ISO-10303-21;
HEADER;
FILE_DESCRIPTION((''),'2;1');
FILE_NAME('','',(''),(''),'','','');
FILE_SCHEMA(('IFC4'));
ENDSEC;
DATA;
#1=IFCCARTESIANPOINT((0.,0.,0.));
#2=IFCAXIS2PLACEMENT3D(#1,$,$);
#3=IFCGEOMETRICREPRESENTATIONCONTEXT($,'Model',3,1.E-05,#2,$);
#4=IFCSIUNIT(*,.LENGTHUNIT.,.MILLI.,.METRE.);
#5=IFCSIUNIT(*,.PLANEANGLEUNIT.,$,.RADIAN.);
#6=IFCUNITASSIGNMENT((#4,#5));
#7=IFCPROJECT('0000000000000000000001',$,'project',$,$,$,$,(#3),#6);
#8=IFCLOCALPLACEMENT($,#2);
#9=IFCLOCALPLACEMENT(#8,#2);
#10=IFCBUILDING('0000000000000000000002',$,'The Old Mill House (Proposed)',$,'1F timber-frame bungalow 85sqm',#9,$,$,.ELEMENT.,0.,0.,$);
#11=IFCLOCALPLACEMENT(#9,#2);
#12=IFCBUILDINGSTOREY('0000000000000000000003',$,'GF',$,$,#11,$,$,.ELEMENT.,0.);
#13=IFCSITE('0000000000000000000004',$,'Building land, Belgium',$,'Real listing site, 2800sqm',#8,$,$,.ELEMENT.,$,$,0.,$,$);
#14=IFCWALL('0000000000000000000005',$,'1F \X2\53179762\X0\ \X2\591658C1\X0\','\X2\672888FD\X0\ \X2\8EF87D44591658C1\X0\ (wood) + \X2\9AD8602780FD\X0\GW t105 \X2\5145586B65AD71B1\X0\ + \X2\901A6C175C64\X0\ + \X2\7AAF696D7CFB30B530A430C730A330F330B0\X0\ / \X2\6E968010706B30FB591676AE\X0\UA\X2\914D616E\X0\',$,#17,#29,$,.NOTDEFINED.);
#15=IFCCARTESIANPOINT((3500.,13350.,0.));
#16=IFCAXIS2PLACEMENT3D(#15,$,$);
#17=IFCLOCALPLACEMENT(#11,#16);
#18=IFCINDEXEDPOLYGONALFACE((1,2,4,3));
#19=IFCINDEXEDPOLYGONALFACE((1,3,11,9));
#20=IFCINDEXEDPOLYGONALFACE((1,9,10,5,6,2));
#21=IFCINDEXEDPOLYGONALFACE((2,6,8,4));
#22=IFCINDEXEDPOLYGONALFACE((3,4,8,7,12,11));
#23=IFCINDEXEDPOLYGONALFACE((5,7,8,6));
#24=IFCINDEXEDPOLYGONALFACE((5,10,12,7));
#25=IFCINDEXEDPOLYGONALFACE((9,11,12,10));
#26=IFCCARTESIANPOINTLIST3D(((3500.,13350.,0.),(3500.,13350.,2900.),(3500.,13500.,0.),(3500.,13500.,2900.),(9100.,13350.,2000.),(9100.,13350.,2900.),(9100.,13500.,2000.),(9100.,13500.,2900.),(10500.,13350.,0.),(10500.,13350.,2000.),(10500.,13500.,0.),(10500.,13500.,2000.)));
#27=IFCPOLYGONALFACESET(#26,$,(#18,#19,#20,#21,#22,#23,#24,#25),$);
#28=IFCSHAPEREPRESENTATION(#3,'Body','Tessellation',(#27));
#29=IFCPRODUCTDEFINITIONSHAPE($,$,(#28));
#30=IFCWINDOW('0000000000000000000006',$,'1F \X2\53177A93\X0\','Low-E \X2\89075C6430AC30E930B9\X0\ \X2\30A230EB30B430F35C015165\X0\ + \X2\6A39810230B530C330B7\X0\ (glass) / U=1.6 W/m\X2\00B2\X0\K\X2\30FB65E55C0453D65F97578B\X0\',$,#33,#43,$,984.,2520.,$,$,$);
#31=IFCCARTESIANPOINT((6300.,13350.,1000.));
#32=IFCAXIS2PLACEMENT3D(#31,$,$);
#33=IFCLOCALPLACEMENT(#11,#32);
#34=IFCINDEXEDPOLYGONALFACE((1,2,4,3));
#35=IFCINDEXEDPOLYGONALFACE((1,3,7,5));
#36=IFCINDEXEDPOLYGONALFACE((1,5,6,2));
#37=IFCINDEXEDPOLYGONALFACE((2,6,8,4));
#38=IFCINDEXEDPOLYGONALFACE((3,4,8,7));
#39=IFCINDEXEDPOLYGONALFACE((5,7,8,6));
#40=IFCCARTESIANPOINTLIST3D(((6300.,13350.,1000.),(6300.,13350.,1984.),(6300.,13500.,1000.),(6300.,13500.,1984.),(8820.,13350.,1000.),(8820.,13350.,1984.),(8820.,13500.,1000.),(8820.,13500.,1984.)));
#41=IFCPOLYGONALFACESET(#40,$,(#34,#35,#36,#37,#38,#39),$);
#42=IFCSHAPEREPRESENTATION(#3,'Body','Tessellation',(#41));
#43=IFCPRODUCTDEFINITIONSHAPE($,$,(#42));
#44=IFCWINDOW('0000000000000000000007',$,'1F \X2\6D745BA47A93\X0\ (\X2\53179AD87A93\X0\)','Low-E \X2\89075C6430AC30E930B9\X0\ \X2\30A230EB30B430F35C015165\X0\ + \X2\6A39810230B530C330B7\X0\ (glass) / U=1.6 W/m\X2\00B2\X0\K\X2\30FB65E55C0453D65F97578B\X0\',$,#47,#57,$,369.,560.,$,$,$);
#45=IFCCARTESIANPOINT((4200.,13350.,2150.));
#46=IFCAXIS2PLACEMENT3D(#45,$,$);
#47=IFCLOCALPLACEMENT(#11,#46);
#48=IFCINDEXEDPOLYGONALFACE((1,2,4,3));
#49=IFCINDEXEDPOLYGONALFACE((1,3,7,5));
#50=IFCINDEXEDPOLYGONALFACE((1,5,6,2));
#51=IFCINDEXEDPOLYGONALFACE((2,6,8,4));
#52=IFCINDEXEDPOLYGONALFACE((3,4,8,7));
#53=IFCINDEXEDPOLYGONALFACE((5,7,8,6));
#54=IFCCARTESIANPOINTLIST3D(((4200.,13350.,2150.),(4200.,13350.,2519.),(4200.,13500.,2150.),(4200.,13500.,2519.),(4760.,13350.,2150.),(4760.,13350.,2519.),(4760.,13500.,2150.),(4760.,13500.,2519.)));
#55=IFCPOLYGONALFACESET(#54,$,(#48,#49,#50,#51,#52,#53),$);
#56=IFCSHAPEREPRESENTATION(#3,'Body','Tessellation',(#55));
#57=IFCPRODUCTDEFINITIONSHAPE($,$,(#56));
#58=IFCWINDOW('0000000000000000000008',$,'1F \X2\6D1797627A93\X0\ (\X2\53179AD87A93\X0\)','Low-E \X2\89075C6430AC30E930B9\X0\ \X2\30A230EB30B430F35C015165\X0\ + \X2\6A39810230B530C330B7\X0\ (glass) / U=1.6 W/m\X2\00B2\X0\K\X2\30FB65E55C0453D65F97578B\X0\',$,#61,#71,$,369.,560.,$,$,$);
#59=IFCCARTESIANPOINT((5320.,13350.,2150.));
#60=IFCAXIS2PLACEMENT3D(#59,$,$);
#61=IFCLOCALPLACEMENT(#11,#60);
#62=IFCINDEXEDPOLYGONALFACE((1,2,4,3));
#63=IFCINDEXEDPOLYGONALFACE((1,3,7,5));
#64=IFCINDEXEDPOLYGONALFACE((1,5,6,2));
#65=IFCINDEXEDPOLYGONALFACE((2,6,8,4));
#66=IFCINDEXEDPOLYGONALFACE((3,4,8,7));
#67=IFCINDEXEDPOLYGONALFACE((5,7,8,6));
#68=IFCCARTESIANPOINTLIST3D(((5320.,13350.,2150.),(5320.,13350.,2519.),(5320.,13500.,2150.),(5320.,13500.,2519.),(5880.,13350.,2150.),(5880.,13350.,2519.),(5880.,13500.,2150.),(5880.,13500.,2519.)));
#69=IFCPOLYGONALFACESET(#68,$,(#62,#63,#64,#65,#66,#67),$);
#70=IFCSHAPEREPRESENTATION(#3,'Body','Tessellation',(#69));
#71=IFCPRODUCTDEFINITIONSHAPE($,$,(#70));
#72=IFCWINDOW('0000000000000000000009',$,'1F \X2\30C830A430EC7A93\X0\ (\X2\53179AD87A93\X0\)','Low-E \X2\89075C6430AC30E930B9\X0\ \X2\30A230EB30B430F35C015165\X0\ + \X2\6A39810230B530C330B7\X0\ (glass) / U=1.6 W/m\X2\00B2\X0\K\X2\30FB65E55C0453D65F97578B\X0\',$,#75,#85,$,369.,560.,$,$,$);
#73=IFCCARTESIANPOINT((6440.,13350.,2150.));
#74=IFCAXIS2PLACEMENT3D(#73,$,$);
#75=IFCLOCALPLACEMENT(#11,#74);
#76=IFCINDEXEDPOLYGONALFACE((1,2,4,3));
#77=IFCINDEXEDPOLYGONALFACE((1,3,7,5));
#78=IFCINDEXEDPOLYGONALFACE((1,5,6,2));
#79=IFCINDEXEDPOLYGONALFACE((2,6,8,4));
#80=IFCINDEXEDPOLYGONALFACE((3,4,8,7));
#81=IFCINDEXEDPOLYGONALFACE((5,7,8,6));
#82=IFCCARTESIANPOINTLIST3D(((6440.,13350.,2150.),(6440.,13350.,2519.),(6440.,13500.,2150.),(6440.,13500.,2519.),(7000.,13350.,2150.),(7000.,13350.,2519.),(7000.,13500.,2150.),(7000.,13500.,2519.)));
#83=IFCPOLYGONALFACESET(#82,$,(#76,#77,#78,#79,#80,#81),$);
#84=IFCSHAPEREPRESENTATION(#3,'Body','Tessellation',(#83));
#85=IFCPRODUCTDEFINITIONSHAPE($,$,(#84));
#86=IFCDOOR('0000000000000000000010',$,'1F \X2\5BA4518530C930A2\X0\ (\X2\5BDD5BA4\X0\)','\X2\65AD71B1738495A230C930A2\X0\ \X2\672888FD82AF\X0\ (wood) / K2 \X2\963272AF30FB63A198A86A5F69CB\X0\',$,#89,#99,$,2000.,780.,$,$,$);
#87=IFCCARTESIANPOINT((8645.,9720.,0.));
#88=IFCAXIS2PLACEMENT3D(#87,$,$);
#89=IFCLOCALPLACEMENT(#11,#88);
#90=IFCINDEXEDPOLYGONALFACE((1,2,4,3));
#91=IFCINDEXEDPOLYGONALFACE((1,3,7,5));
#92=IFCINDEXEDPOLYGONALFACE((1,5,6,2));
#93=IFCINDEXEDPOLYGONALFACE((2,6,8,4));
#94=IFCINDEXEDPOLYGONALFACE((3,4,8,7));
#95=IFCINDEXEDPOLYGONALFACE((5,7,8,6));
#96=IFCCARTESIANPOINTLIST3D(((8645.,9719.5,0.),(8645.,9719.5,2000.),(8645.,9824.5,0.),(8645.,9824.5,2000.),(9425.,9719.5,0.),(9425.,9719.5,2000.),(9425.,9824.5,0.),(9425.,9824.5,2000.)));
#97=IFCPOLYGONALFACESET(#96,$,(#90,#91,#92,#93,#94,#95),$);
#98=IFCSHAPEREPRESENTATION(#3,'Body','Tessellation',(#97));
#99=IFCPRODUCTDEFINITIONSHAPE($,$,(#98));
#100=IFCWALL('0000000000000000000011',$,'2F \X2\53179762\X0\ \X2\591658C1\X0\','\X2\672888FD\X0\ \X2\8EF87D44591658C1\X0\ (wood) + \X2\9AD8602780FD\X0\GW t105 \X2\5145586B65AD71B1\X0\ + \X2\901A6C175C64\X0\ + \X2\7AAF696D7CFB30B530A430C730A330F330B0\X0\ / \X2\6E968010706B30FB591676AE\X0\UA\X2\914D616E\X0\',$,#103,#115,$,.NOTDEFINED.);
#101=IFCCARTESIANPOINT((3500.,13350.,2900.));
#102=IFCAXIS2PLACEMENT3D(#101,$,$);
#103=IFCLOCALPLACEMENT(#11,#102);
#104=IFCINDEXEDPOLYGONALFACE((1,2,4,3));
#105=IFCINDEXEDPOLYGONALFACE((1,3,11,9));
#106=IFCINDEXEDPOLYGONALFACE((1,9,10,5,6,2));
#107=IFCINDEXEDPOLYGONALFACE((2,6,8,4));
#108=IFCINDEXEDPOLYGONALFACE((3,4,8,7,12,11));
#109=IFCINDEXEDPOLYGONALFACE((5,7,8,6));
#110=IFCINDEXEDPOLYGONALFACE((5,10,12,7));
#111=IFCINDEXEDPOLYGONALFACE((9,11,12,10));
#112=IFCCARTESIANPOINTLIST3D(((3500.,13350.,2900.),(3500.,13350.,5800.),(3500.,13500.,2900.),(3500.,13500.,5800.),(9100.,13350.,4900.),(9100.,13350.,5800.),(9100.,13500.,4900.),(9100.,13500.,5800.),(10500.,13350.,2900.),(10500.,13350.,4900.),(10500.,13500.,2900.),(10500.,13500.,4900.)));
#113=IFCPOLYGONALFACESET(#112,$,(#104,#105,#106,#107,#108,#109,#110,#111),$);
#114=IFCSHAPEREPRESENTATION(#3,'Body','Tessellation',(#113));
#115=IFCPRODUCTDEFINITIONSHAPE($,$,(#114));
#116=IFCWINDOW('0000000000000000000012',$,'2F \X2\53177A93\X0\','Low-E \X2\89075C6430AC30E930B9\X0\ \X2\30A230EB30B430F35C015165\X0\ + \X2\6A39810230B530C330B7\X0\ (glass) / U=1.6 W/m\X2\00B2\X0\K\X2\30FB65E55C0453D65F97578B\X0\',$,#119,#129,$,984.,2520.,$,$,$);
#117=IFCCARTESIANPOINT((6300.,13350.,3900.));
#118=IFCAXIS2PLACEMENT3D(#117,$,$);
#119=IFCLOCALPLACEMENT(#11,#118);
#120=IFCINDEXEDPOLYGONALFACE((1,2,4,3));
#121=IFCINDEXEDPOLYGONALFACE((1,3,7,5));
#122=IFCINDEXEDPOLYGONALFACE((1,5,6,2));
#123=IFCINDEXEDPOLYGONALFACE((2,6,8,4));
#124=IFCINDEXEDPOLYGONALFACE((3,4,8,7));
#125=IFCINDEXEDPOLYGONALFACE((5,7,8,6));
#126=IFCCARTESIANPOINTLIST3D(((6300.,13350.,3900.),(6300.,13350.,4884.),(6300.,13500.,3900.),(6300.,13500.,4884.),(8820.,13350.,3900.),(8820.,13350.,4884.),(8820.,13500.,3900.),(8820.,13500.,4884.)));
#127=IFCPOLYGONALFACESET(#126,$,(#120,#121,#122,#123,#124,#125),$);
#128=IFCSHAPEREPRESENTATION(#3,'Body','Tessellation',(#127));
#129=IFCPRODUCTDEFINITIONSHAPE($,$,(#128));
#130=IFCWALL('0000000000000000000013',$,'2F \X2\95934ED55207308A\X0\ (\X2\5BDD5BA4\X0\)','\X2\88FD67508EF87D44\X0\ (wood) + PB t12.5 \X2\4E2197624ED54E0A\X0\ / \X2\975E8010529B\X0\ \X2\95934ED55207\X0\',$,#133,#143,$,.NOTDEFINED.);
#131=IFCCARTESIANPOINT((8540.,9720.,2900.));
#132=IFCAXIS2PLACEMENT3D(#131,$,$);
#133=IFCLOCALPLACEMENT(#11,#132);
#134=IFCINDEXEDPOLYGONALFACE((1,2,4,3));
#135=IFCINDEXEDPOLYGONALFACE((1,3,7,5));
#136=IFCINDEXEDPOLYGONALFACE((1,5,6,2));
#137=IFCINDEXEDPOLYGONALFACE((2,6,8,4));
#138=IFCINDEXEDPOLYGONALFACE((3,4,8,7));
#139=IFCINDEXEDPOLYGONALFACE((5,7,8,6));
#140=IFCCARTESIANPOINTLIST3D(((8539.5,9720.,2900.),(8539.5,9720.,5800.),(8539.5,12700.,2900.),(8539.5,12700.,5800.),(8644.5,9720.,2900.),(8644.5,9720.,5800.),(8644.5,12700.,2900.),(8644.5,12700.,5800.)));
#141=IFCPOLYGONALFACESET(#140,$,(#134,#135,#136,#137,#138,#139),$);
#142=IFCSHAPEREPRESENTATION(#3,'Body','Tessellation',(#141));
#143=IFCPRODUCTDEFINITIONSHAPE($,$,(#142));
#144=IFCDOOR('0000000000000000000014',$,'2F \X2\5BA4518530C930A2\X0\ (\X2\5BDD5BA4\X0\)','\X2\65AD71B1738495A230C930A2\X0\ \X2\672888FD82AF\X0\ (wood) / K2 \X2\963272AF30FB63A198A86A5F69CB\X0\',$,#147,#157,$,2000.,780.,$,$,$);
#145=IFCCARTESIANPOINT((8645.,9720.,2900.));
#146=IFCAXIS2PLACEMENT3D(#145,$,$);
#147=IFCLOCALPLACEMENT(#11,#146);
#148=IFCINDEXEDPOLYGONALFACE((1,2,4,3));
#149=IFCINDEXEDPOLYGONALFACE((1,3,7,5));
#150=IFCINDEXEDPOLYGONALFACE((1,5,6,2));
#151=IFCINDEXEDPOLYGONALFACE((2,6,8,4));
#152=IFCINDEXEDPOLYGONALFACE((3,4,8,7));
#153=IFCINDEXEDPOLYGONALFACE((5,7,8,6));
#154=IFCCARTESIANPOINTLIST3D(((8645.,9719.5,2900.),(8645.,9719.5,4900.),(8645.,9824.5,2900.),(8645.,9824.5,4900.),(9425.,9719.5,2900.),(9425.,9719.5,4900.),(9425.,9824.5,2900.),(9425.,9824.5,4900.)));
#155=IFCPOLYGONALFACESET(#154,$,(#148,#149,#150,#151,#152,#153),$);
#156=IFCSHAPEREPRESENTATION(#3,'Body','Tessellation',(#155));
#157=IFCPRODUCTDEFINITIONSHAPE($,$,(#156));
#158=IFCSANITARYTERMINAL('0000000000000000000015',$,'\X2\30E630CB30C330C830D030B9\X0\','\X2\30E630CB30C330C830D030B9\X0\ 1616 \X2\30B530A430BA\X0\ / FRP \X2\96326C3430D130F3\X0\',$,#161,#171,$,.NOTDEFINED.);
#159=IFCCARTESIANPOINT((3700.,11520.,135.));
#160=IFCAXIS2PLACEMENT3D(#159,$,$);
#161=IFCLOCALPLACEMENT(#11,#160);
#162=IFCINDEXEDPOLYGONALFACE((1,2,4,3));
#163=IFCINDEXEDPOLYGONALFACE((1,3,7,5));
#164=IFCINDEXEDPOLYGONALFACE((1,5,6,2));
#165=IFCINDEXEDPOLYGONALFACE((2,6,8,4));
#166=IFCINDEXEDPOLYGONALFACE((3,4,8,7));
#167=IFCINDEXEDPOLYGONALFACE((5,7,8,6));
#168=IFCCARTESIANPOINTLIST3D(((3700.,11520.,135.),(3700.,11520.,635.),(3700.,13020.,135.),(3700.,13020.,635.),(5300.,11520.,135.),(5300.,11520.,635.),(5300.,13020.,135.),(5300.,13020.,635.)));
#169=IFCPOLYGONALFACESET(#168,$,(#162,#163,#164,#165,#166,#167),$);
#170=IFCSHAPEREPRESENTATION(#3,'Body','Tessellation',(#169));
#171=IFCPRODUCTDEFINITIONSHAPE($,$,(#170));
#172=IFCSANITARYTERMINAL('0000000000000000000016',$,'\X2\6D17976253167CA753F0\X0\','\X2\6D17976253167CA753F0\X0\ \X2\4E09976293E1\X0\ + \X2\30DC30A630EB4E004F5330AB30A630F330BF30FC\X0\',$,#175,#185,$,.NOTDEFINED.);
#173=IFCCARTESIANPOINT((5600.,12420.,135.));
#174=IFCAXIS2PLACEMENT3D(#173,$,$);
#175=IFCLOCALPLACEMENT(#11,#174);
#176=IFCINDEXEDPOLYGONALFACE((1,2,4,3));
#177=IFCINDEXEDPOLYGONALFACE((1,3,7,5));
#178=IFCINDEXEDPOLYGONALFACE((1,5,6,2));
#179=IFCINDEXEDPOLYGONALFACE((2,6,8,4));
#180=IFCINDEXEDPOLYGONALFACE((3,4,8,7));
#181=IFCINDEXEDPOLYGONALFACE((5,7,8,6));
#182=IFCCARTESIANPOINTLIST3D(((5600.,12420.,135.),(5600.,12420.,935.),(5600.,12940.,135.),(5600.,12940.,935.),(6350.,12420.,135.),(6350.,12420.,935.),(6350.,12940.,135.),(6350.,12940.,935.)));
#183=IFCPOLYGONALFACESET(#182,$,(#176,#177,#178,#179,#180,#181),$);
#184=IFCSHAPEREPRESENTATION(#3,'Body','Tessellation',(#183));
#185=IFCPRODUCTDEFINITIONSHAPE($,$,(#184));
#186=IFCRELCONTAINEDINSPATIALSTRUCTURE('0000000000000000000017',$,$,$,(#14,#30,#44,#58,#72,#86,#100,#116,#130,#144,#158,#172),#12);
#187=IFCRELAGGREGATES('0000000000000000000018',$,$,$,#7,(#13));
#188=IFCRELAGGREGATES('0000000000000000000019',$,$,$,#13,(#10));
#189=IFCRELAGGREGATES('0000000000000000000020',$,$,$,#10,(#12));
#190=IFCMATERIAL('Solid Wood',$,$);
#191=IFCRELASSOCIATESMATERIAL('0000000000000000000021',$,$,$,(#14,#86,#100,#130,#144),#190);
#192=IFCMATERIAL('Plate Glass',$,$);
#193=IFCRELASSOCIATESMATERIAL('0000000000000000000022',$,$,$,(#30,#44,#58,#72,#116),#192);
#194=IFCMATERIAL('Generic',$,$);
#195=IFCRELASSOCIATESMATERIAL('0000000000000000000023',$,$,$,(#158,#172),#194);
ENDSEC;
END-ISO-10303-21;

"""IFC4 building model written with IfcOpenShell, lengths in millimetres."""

from ifc_helpers import new_model, si_unit, frame, frame_2d, origin, place, context, project, spatial, rectangle, extrude, material, element, fill, save


model = new_model("IFC4")

# Units and contexts
model_context = context("Model", 3, precision=1e-05, world=origin())
ifc_project = project(units=[si_unit("LENGTHUNIT", "METRE", prefix="MILLI"), si_unit("PLANEANGLEUNIT", "RADIAN")], contexts=[model_context])

# Site, building, storey
site_placement = place(None, origin())
site = spatial("IfcSite", under=ifc_project, at=site_placement, Name="Building land, Belgium", ObjectType="Real listing site, 2800sqm", CompositionType="ELEMENT", RefElevation=0.0)
building_placement = place(site_placement, origin())
building = spatial("IfcBuilding", under=site, at=building_placement, Name="The Old Mill House (Proposed)", ObjectType="1F timber-frame bungalow 85sqm", CompositionType="ELEMENT", ElevationOfRefHeight=0.0, ElevationOfTerrain=0.0)
storey_placement = place(building_placement, origin())
storey = spatial("IfcBuildingStorey", under=building, at=storey_placement, Name="GF", CompositionType="ELEMENT", Elevation=0.0)

# Wall, openings, windows
ifc_material_1 = material(Name="Solid Wood")
wall_1_placement = place(storey_placement, frame((3500.0, 13350.0, 0.0)))
wall_1 = element("IfcWall", 1, at=wall_1_placement, inside=storey, material=ifc_material_1, Name="1F 北面 外壁", Description="木製 軸組外壁 (wood) + 高性能GW t105 充填断熱 + 通気層 + 窯業系サイディング / 準耐火・外皮UA配慮", PredefinedType="NOTDEFINED", context=model_context, shape_type="SweptSolid", body=[
    extrude(rectangle(XDim=7000.0, YDim=150.0, at=frame_2d((3500.0, 75.0))), frame((3500.0, 13350.0, 0.0)), (0.0, 0.0, 1.0), 2900.0),
])
opening_1_placement = place(storey_placement, frame((6300.0, 13350.0, 1000.0)))
opening_1 = element("IfcOpeningElement", 2, at=opening_1_placement, cuts=wall_1, PredefinedType="NOTDEFINED", context=model_context, shape_type="SweptSolid", body=[
    extrude(rectangle(XDim=2520.0, YDim=150.0, at=frame_2d((1260.0, 75.0))), frame((6300.0, 13350.0, 1000.0)), (0.0, 0.0, 1.0), 984.0),
])
opening_2_placement = place(storey_placement, frame((4200.0, 13350.0, 2150.0)))
opening_2 = element("IfcOpeningElement", 3, at=opening_2_placement, cuts=wall_1, PredefinedType="NOTDEFINED", context=model_context, shape_type="SweptSolid", body=[
    extrude(rectangle(XDim=560.0, YDim=150.0, at=frame_2d((280.0, 75.0))), frame((4200.0, 13350.0, 2150.0)), (0.0, 0.0, 1.0), 369.0),
])
opening_3_placement = place(storey_placement, frame((5320.0, 13350.0, 2150.0)))
opening_3 = element("IfcOpeningElement", 4, at=opening_3_placement, cuts=wall_1, PredefinedType="NOTDEFINED", context=model_context, shape_type="SweptSolid", body=[
    extrude(rectangle(XDim=560.0, YDim=150.0, at=frame_2d((280.0, 75.0))), frame((5320.0, 13350.0, 2150.0)), (0.0, 0.0, 1.0), 369.0),
])
opening_4_placement = place(storey_placement, frame((6440.0, 13350.0, 2150.0)))
opening_4 = element("IfcOpeningElement", 5, at=opening_4_placement, cuts=wall_1, PredefinedType="NOTDEFINED", context=model_context, shape_type="SweptSolid", body=[
    extrude(rectangle(XDim=560.0, YDim=150.0, at=frame_2d((280.0, 75.0))), frame((6440.0, 13350.0, 2150.0)), (0.0, 0.0, 1.0), 369.0),
])
ifc_material_2 = material(Name="Plate Glass")
window_1_placement = place(storey_placement, frame((6300.0, 13350.0, 1000.0)))
window_1 = element("IfcWindow", 6, at=window_1_placement, inside=storey, material=ifc_material_2, Name="1F 北窓", Description="Low-E 複層ガラス アルゴン封入 + 樹脂サッシ (glass) / U=1.6 W/m²K・日射取得型", OverallHeight=984.0, OverallWidth=2520.0, context=model_context, shape_type="SweptSolid", body=[
    extrude(rectangle(XDim=2520.0, YDim=150.0, at=frame_2d((1260.0, 75.0))), frame((6300.0, 13350.0, 1000.0)), (0.0, 0.0, 1.0), 984.0),
])
fill(opening_1, window_1)
window_2_placement = place(storey_placement, frame((4200.0, 13350.0, 2150.0)))
window_2 = element("IfcWindow", 7, at=window_2_placement, inside=storey, material=ifc_material_2, Name="1F 浴室窓 (北高窓)", Description="Low-E 複層ガラス アルゴン封入 + 樹脂サッシ (glass) / U=1.6 W/m²K・日射取得型", OverallHeight=369.0, OverallWidth=560.0, context=model_context, shape_type="SweptSolid", body=[
    extrude(rectangle(XDim=560.0, YDim=150.0, at=frame_2d((280.0, 75.0))), frame((4200.0, 13350.0, 2150.0)), (0.0, 0.0, 1.0), 369.0),
])
fill(opening_2, window_2)
window_3_placement = place(storey_placement, frame((5320.0, 13350.0, 2150.0)))
window_3 = element("IfcWindow", 8, at=window_3_placement, inside=storey, material=ifc_material_2, Name="1F 洗面窓 (北高窓)", Description="Low-E 複層ガラス アルゴン封入 + 樹脂サッシ (glass) / U=1.6 W/m²K・日射取得型", OverallHeight=369.0, OverallWidth=560.0, context=model_context, shape_type="SweptSolid", body=[
    extrude(rectangle(XDim=560.0, YDim=150.0, at=frame_2d((280.0, 75.0))), frame((5320.0, 13350.0, 2150.0)), (0.0, 0.0, 1.0), 369.0),
])
fill(opening_3, window_3)
window_4_placement = place(storey_placement, frame((6440.0, 13350.0, 2150.0)))
window_4 = element("IfcWindow", 9, at=window_4_placement, inside=storey, material=ifc_material_2, Name="1F トイレ窓 (北高窓)", Description="Low-E 複層ガラス アルゴン封入 + 樹脂サッシ (glass) / U=1.6 W/m²K・日射取得型", OverallHeight=369.0, OverallWidth=560.0, context=model_context, shape_type="SweptSolid", body=[
    extrude(rectangle(XDim=560.0, YDim=150.0, at=frame_2d((280.0, 75.0))), frame((6440.0, 13350.0, 2150.0)), (0.0, 0.0, 1.0), 369.0),
])
fill(opening_4, window_4)

# Door
door_1_placement = place(storey_placement, frame((8645.0, 9720.0, 0.0)))
element("IfcDoor", 10, at=door_1_placement, inside=storey, material=ifc_material_1, Name="1F 室内ドア (寝室)", Description="断熱玄関ドア 木製芯 (wood) / K2 防犯・採風機構", OverallHeight=2000.0, OverallWidth=780.0, context=model_context, shape_type="SweptSolid", body=[
    extrude(rectangle(XDim=780.0, YDim=105.0, at=frame_2d((390.0, 52.0))), frame((8645.0, 9720.0, 0.0)), (0.0, 0.0, 1.0), 2000.0),
])

# Wall, opening, window
wall_2_placement = place(storey_placement, frame((3500.0, 13350.0, 2900.0)))
wall_2 = element("IfcWall", 11, at=wall_2_placement, inside=storey, material=ifc_material_1, Name="2F 北面 外壁", Description="木製 軸組外壁 (wood) + 高性能GW t105 充填断熱 + 通気層 + 窯業系サイディング / 準耐火・外皮UA配慮", PredefinedType="NOTDEFINED", context=model_context, shape_type="SweptSolid", body=[
    extrude(rectangle(XDim=7000.0, YDim=150.0, at=frame_2d((3500.0, 75.0))), frame((3500.0, 13350.0, 2900.0)), (0.0, 0.0, 1.0), 2900.0),
])
opening_5_placement = place(storey_placement, frame((6300.0, 13350.0, 3900.0)))
opening_5 = element("IfcOpeningElement", 12, at=opening_5_placement, cuts=wall_2, PredefinedType="NOTDEFINED", context=model_context, shape_type="SweptSolid", body=[
    extrude(rectangle(XDim=2520.0, YDim=150.0, at=frame_2d((1260.0, 75.0))), frame((6300.0, 13350.0, 3900.0)), (0.0, 0.0, 1.0), 984.0),
])
window_5_placement = place(storey_placement, frame((6300.0, 13350.0, 3900.0)))
window_5 = element("IfcWindow", 13, at=window_5_placement, inside=storey, material=ifc_material_2, Name="2F 北窓", Description="Low-E 複層ガラス アルゴン封入 + 樹脂サッシ (glass) / U=1.6 W/m²K・日射取得型", OverallHeight=984.0, OverallWidth=2520.0, context=model_context, shape_type="SweptSolid", body=[
    extrude(rectangle(XDim=2520.0, YDim=150.0, at=frame_2d((1260.0, 75.0))), frame((6300.0, 13350.0, 3900.0)), (0.0, 0.0, 1.0), 984.0),
])
fill(opening_5, window_5)

# Wall
wall_3_placement = place(storey_placement, frame((8540.0, 9720.0, 2900.0)))
element("IfcWall", 14, at=wall_3_placement, inside=storey, material=ifc_material_1, Name="2F 間仕切り (寝室)", Description="製材軸組 (wood) + PB t12.5 両面仕上 / 非耐力 間仕切", PredefinedType="NOTDEFINED", context=model_context, shape_type="SweptSolid", body=[
    extrude(rectangle(XDim=105.0, YDim=2980.0, at=frame_2d((52.0, 1490.0))), frame((8540.0, 9720.0, 2900.0)), (0.0, 0.0, 1.0), 2900.0),
])

# Door
door_2_placement = place(storey_placement, frame((8645.0, 9720.0, 2900.0)))
element("IfcDoor", 15, at=door_2_placement, inside=storey, material=ifc_material_1, Name="2F 室内ドア (寝室)", Description="断熱玄関ドア 木製芯 (wood) / K2 防犯・採風機構", OverallHeight=2000.0, OverallWidth=780.0, context=model_context, shape_type="SweptSolid", body=[
    extrude(rectangle(XDim=780.0, YDim=105.0, at=frame_2d((390.0, 52.0))), frame((8645.0, 9720.0, 2900.0)), (0.0, 0.0, 1.0), 2000.0),
])

# Sanitary terminals
ifc_material_3 = material(Name="Generic")
sanitary_terminal_1_placement = place(storey_placement, frame((3700.0, 11520.0, 135.0)))
element("IfcSanitaryTerminal", 16, at=sanitary_terminal_1_placement, inside=storey, material=ifc_material_3, Name="ユニットバス", Description="ユニットバス 1616 サイズ / FRP 防水パン", PredefinedType="NOTDEFINED", context=model_context, shape_type="SweptSolid", body=[
    extrude(rectangle(XDim=1600.0, YDim=1500.0, at=frame_2d((800.0, 750.0))), frame((3700.0, 11520.0, 135.0)), (0.0, 0.0, 1.0), 500.0),
])
sanitary_terminal_2_placement = place(storey_placement, frame((5600.0, 12420.0, 135.0)))
element("IfcSanitaryTerminal", 17, at=sanitary_terminal_2_placement, inside=storey, material=ifc_material_3, Name="洗面化粧台", Description="洗面化粧台 三面鏡 + ボウル一体カウンター", PredefinedType="NOTDEFINED", context=model_context, shape_type="SweptSolid", body=[
    extrude(rectangle(XDim=750.0, YDim=520.0, at=frame_2d((375.0, 260.0))), frame((5600.0, 12420.0, 135.0)), (0.0, 0.0, 1.0), 800.0),
])

save(model, "model.ifc")
